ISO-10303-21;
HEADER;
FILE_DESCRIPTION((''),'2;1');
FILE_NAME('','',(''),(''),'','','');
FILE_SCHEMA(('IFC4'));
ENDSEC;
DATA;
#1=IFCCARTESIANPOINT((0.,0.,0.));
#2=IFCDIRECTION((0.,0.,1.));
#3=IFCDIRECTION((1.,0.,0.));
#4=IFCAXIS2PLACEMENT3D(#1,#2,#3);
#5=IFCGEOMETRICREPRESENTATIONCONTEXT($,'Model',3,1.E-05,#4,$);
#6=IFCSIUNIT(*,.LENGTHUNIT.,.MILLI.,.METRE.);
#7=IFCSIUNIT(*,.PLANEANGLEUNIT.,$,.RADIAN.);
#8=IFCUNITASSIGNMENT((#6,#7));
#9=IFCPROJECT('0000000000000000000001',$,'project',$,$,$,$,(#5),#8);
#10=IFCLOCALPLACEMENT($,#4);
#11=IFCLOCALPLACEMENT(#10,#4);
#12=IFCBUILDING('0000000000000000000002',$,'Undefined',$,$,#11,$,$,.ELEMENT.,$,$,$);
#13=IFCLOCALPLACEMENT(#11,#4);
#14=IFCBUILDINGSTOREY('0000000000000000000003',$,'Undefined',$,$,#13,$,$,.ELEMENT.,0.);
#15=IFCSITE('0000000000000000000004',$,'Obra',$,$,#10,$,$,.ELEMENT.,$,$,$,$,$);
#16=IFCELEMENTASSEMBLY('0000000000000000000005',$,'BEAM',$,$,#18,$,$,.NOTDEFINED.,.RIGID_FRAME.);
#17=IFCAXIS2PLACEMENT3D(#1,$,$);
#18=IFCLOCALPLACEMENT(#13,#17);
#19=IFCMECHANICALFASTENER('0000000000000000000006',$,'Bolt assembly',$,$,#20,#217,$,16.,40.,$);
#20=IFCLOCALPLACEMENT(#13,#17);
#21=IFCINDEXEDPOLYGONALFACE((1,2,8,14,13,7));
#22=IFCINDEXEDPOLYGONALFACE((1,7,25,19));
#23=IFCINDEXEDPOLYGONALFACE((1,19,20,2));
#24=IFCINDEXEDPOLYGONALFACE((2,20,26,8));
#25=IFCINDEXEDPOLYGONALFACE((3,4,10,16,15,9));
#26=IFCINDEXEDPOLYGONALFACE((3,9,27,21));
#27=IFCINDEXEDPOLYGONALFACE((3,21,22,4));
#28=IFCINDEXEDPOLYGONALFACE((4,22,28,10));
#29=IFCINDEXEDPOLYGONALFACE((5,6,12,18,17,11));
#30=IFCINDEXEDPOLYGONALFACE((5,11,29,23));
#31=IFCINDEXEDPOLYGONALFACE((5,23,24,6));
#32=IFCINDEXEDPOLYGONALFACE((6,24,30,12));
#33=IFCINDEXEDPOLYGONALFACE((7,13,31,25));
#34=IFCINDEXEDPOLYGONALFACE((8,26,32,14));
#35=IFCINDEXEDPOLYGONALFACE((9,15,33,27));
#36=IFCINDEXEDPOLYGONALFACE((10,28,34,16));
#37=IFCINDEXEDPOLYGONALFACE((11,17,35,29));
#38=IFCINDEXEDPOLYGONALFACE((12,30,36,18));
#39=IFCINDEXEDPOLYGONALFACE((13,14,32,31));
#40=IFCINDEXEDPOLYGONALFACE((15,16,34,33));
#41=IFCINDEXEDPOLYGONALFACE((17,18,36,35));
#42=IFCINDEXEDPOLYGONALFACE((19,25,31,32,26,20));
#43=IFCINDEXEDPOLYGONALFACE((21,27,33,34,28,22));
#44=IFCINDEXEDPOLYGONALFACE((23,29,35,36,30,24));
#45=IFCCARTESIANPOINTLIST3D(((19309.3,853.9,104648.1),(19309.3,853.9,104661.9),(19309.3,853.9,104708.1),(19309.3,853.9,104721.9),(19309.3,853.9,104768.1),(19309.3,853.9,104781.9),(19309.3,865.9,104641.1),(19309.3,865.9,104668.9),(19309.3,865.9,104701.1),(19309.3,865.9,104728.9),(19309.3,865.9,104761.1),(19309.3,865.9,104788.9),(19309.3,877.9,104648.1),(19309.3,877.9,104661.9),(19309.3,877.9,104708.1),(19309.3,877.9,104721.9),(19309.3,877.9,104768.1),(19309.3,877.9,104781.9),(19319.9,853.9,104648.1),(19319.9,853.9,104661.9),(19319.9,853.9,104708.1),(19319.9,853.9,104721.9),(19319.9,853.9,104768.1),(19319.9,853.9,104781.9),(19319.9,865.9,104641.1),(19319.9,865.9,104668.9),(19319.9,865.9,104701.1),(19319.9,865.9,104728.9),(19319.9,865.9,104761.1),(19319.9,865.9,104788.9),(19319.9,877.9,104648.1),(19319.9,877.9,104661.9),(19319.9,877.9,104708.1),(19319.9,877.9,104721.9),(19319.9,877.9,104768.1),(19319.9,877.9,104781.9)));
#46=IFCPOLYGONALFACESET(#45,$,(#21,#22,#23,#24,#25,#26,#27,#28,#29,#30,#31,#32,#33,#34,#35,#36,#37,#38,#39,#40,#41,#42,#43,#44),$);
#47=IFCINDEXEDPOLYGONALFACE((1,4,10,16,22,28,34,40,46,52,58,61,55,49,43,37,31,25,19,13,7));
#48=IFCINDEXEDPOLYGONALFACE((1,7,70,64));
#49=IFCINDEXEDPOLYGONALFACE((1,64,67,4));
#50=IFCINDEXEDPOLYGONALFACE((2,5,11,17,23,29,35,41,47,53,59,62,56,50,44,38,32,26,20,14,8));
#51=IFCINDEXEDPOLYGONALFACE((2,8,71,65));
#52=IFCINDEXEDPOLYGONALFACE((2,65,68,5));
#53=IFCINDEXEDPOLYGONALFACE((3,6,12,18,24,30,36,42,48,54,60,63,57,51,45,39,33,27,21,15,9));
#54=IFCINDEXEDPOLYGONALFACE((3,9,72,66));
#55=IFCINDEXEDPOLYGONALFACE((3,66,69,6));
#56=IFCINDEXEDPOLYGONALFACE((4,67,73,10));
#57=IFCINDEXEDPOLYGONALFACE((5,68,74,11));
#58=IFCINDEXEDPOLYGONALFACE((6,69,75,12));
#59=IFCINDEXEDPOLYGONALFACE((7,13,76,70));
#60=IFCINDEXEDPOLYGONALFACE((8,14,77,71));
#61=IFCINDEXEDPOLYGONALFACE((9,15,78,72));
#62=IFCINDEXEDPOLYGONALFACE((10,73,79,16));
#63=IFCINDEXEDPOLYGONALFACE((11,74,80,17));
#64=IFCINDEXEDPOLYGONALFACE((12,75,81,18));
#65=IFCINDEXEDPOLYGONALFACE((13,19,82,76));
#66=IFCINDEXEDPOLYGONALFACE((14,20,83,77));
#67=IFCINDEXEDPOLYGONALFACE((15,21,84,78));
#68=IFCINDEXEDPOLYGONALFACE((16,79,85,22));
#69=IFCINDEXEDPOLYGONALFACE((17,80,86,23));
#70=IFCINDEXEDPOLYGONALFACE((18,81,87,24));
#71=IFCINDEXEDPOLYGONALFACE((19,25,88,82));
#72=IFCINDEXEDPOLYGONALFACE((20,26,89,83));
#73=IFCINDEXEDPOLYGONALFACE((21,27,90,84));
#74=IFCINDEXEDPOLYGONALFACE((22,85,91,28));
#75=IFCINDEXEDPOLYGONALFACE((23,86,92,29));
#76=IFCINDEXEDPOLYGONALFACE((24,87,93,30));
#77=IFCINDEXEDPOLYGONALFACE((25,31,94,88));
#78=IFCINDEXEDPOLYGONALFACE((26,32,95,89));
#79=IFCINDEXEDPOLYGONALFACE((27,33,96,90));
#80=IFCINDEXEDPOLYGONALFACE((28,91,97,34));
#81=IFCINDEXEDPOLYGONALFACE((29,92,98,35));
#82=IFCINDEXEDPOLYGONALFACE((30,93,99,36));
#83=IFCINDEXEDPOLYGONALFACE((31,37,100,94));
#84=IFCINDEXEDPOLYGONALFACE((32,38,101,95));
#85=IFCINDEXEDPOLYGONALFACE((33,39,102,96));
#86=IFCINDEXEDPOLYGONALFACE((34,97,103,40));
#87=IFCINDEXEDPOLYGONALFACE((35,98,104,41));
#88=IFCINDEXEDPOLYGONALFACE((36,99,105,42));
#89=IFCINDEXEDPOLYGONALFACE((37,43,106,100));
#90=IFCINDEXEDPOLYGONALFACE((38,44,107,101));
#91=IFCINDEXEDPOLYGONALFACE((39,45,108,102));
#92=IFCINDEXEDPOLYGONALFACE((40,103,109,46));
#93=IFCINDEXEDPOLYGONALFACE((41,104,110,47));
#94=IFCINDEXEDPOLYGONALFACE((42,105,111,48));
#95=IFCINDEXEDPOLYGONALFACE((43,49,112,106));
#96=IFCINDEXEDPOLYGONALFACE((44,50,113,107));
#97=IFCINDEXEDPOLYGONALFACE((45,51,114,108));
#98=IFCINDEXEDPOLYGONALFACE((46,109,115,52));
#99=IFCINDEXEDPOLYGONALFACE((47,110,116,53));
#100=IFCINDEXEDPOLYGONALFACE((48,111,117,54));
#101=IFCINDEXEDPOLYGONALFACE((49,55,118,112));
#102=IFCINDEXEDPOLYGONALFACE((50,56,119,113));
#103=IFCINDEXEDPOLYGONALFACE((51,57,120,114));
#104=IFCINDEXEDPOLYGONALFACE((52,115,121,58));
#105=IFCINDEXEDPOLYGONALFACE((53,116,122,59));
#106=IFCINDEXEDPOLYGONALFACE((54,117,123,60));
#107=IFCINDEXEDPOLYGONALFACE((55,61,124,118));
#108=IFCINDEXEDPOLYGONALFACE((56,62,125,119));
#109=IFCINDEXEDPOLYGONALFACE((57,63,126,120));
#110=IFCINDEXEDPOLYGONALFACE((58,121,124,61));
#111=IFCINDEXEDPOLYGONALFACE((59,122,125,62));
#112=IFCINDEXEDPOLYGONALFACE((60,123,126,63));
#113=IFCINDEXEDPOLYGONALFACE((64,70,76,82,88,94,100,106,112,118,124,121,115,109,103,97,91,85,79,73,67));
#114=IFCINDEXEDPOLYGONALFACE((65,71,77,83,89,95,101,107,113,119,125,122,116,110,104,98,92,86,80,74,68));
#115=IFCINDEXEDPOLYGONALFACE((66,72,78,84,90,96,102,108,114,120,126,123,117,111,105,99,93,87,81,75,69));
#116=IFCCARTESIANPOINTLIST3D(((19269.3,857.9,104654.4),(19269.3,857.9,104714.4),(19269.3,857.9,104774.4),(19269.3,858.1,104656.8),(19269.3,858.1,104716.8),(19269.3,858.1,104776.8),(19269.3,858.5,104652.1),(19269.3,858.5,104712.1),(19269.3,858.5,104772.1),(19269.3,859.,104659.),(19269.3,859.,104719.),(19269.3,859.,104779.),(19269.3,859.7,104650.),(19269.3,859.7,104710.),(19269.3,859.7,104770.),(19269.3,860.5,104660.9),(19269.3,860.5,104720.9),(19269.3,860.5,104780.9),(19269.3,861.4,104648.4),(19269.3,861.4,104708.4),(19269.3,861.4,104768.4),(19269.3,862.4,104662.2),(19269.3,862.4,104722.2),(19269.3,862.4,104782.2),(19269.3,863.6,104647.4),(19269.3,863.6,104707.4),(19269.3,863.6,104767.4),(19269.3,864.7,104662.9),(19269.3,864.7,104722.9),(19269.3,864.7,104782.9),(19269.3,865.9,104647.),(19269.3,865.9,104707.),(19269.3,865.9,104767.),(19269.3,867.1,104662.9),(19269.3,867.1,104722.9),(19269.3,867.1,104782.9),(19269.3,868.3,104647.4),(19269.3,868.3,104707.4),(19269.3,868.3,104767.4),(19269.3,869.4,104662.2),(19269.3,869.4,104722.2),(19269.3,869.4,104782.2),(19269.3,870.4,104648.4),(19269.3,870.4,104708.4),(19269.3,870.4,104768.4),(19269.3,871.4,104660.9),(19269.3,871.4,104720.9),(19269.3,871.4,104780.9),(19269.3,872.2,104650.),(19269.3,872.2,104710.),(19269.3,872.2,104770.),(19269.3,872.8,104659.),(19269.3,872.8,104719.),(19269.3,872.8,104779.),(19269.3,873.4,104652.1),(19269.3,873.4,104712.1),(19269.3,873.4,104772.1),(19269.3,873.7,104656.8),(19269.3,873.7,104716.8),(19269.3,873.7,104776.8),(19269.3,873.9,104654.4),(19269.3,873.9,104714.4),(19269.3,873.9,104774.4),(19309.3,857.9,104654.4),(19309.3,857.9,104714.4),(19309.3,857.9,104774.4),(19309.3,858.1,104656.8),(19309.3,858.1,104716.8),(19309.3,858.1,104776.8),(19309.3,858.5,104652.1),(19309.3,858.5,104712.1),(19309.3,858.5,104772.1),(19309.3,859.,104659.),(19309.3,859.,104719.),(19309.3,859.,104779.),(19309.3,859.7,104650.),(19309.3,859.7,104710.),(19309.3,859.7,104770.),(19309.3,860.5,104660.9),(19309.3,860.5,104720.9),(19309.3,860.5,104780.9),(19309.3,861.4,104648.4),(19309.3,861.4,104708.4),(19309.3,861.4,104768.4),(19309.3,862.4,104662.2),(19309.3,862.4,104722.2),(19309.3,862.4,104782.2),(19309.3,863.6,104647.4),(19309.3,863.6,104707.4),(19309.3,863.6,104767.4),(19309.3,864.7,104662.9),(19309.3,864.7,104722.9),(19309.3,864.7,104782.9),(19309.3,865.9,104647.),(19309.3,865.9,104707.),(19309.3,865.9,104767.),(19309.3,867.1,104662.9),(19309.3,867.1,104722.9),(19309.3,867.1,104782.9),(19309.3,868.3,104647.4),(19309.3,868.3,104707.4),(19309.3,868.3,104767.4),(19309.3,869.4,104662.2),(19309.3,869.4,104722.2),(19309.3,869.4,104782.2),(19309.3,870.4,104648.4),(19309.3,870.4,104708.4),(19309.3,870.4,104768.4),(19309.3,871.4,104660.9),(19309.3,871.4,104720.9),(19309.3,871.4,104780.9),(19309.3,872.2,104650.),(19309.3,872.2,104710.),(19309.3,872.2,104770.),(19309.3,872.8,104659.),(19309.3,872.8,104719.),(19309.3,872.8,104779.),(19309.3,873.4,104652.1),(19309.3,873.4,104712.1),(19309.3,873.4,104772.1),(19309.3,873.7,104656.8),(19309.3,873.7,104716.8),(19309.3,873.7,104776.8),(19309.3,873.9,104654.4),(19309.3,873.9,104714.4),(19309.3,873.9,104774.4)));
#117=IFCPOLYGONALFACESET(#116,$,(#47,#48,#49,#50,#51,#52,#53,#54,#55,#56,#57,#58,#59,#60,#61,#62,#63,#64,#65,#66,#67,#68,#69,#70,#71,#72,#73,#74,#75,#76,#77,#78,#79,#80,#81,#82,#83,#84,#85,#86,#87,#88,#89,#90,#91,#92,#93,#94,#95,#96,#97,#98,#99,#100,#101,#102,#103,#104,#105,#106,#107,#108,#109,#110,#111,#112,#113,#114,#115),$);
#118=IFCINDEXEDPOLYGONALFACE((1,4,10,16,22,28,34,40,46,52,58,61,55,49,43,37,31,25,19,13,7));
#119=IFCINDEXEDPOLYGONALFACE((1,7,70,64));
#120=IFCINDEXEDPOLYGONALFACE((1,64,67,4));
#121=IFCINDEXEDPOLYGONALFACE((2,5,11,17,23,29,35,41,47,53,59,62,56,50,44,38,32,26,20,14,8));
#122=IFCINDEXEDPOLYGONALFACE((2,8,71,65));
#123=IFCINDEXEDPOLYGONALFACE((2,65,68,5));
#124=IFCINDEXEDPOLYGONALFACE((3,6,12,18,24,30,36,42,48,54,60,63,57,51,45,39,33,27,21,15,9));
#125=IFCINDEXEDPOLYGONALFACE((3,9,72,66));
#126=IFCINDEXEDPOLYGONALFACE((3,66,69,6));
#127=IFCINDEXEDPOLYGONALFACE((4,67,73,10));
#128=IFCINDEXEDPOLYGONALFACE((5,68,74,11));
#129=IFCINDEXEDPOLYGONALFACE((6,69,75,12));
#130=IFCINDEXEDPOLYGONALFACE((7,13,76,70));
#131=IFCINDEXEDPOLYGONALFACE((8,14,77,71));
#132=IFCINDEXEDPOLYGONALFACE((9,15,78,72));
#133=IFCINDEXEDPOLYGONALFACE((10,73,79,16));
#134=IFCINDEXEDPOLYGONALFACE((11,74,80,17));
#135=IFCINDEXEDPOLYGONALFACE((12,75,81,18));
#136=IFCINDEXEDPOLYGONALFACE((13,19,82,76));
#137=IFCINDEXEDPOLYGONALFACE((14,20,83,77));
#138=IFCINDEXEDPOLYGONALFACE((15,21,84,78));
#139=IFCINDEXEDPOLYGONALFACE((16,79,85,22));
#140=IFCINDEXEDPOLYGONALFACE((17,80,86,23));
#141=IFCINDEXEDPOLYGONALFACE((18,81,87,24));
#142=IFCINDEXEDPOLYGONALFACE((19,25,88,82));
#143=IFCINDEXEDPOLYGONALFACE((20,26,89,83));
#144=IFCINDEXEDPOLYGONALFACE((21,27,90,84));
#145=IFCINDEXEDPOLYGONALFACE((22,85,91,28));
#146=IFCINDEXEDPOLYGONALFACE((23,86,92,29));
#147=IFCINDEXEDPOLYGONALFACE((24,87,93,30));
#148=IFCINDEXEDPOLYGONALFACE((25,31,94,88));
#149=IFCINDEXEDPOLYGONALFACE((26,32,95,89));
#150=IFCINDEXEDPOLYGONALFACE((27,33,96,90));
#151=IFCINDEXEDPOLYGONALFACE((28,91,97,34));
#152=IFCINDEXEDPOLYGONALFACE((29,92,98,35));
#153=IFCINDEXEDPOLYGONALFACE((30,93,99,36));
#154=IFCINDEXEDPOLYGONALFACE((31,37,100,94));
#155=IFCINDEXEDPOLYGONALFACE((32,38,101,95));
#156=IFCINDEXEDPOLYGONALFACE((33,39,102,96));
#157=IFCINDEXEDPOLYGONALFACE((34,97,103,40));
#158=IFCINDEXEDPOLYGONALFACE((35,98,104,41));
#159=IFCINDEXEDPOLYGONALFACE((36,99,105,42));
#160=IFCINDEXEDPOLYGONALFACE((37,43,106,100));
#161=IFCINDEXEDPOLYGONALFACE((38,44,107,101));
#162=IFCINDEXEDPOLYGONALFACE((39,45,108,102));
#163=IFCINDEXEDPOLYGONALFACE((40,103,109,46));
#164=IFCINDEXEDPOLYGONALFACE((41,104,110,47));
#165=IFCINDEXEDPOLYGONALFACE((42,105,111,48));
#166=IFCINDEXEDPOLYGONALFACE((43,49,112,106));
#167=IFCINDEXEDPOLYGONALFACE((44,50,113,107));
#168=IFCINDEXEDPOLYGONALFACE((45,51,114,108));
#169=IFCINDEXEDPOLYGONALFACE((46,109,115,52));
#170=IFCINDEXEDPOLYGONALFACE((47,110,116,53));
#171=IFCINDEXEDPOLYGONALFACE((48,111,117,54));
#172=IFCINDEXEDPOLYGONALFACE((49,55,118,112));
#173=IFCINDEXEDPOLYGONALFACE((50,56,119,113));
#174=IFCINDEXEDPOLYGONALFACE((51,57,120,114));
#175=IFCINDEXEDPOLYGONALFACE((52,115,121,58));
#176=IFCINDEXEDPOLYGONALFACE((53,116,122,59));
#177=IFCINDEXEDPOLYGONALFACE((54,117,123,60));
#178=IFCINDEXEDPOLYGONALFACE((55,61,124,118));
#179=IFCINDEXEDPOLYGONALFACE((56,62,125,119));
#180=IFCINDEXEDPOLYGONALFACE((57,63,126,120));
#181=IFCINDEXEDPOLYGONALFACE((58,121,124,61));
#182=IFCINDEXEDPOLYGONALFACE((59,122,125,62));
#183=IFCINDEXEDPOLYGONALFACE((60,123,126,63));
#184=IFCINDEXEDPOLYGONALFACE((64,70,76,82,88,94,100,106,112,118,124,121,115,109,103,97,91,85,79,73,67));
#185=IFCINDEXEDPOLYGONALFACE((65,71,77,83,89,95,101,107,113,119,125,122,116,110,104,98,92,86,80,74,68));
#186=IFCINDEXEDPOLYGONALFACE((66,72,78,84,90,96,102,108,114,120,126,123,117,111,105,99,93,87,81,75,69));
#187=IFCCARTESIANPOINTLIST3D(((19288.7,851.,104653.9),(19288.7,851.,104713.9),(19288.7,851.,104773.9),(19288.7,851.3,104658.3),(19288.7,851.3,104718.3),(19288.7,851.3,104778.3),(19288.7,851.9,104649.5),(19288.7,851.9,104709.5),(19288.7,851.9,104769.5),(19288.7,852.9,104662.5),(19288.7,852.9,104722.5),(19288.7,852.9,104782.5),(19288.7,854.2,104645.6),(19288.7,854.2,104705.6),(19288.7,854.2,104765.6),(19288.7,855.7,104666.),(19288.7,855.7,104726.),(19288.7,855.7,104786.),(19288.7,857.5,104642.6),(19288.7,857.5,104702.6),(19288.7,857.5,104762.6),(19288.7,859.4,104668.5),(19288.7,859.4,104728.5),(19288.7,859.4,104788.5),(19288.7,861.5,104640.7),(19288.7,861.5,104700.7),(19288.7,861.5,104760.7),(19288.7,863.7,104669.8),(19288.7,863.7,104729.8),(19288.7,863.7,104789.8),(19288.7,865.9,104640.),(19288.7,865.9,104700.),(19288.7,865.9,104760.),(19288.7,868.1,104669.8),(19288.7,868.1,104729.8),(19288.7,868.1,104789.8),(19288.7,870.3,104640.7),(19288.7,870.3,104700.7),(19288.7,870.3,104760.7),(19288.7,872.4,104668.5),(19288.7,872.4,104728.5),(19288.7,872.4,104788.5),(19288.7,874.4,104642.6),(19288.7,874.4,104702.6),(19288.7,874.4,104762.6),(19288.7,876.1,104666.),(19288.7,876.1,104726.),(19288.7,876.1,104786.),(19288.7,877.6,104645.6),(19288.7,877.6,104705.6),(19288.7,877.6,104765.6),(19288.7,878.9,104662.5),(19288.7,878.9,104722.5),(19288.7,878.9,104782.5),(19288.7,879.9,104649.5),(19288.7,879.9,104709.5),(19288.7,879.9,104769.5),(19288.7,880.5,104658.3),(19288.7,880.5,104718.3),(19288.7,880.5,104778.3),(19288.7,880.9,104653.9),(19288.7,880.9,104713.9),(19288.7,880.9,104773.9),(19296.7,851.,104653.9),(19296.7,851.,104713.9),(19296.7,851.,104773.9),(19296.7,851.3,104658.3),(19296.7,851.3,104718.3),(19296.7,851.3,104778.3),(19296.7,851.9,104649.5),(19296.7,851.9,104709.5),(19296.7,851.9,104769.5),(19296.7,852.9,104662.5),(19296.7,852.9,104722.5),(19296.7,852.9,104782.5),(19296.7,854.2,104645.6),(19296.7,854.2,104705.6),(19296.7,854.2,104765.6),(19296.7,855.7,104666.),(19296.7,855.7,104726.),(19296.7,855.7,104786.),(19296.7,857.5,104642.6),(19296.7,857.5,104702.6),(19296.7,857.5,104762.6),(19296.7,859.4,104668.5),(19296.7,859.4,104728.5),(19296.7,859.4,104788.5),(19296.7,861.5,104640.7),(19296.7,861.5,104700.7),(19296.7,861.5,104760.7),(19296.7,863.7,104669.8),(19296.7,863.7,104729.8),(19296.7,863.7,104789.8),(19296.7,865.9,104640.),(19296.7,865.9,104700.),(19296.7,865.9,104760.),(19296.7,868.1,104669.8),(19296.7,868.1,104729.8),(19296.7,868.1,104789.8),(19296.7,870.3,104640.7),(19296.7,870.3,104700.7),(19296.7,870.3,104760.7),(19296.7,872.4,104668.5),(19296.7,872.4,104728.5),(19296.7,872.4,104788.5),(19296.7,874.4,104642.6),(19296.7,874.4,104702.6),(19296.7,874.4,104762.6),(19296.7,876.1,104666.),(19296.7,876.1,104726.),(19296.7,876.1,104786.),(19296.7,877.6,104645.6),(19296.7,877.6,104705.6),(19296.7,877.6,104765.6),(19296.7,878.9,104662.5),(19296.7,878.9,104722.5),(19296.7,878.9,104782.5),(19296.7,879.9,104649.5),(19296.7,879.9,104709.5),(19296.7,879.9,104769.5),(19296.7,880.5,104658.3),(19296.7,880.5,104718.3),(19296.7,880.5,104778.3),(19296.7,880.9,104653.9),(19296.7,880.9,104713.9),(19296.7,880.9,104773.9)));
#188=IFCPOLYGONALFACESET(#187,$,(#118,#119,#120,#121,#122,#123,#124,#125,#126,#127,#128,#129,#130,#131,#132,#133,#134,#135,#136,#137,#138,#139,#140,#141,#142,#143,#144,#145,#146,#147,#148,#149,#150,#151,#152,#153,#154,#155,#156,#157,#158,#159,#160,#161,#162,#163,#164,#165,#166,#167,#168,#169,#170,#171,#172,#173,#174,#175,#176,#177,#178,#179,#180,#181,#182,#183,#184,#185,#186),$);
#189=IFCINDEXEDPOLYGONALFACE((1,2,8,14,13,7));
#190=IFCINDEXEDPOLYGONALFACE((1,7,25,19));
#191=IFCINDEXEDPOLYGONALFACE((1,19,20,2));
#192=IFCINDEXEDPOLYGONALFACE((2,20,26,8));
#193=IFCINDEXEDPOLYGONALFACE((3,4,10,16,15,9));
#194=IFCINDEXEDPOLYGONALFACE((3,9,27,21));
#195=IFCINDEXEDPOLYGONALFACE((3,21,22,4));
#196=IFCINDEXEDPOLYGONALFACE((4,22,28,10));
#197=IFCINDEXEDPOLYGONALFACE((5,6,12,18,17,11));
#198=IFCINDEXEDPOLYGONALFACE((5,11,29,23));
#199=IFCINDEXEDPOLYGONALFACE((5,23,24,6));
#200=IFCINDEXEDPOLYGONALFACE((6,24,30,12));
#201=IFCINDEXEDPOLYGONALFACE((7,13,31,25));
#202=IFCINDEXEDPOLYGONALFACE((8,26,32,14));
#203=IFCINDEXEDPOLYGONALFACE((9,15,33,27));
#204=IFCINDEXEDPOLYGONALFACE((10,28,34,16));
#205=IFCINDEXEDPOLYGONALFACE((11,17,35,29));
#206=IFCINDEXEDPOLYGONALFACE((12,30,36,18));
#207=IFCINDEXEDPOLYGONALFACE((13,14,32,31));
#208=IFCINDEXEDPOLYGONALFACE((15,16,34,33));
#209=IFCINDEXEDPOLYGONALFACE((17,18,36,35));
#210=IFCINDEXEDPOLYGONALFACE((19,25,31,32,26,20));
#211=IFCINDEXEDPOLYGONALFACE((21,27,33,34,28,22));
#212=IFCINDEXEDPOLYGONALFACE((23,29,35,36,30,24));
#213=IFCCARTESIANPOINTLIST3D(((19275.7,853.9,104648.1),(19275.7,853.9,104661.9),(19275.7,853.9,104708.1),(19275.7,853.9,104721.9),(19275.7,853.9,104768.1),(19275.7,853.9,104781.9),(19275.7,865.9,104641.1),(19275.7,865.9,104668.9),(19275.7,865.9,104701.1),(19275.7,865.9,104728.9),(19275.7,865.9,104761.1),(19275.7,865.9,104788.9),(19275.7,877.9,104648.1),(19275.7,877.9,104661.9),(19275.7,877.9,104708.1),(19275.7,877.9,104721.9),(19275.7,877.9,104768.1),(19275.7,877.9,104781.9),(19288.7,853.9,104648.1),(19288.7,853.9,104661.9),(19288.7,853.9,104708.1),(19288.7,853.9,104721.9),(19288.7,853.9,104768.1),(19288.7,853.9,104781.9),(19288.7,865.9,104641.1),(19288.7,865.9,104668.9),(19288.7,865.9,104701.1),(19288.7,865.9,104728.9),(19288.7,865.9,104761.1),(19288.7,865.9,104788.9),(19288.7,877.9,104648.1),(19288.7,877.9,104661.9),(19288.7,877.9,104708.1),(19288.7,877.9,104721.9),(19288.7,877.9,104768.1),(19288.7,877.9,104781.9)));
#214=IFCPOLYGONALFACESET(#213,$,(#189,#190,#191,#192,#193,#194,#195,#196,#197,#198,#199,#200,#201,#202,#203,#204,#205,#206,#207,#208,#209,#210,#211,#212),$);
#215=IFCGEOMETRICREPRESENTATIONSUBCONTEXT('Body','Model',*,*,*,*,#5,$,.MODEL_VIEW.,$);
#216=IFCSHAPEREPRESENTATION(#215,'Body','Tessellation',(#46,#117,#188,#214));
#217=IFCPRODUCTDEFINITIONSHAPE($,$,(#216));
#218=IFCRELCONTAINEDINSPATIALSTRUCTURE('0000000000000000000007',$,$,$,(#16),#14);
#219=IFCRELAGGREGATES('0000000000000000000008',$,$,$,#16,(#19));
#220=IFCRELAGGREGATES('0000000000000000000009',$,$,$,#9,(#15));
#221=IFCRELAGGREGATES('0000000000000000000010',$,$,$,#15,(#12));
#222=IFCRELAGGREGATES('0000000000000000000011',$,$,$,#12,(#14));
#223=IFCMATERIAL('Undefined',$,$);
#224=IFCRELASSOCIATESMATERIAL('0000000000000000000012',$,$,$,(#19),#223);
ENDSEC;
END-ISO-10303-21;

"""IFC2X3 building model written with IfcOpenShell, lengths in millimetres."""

from ifc_helpers import new_model, si_unit, frame, origin_with_axes, origin_2d_with_axis, place, context, subcontext, project, spatial, polyline, circle, outline, extrude, source, transform, mapped, material, element, aggregate, save


model = new_model("IFC2X3")

# Units and contexts
model_context = context("Model", 3, precision=1e-05, world=origin_with_axes())
body_context = subcontext(model_context, "Body", "Model", "MODEL_VIEW")
ifc_project = project(units=[si_unit("LENGTHUNIT", "METRE", prefix="MILLI"), si_unit("PLANEANGLEUNIT", "RADIAN")], contexts=[model_context])

# Site, building, storey
site_placement = place(None, origin_with_axes())
site = spatial("IfcSite", under=ifc_project, at=site_placement, Name="Obra", CompositionType="ELEMENT")
building_placement = place(site_placement, origin_with_axes())
building = spatial("IfcBuilding", under=site, at=building_placement, Name="Undefined", CompositionType="ELEMENT")
storey_placement = place(building_placement, origin_with_axes())
storey = spatial("IfcBuildingStorey", under=building, at=storey_placement, Name="Undefined", CompositionType="ELEMENT", Elevation=0.0)

# Element assembly, mechanical fastener
assembly_1_placement = place(storey_placement, origin_with_axes())
assembly_1 = element("IfcElementAssembly", 1, at=assembly_1_placement, inside=storey, Name="BEAM", AssemblyPlace="NOTDEFINED", PredefinedType="RIGID_FRAME")
ifc_material_1 = material(Name="Undefined")
shared_shape_1 = source(origin_with_axes(), body_context, "Body", "SweptSolid", [
    extrude(outline(polyline([(13.9, 0.0), (6.9, 12.0), (-6.9, 12.0), (-13.9, 0.0), (-6.9, -12.0), (6.9, -12.0), (13.9, 0.0)])), frame((0.0, -19.9, 0.0), z_axis=(0.0, 1.0, 0.0), x_axis=(1.0, 0.0, 0.0)), (0.0, 0.0, 1.0), 10.6),
    extrude(circle(Radius=8.0, at=origin_2d_with_axis()), frame((0.0, -9.3, 0.0), z_axis=(0.0, 1.0, 0.0), x_axis=(1.0, 0.0, 0.0)), (0.0, 0.0, 1.0), 40.0),
    extrude(circle(Radius=15.0, at=origin_2d_with_axis()), frame((0.0, 3.3, 0.0), z_axis=(0.0, 1.0, 0.0), x_axis=(1.0, 0.0, 0.0)), (0.0, 0.0, 1.0), 8.0),
    extrude(outline(polyline([(13.9, 0.0), (6.9, 12.0), (-6.9, 12.0), (-13.9, 0.0), (-6.9, -12.0), (6.9, -12.0), (13.9, 0.0)])), frame((0.0, 11.3, 0.0), z_axis=(0.0, 1.0, 0.0), x_axis=(1.0, 0.0, 0.0)), (0.0, 0.0, 1.0), 13.0),
])
mechanical_fastener_1_placement = place(assembly_1_placement, frame((19300.0, 830.9, 104850.0), z_axis=(0.0, 1.0, 0.0), x_axis=(0.0, 0.0, -1.0)))
mechanical_fastener_1 = element("IfcMechanicalFastener", 2, at=mechanical_fastener_1_placement, material=ifc_material_1, Name="Bolt assembly", NominalDiameter=16.0, NominalLength=40.0, context=body_context, shape_type="MappedRepresentation", body=[
    mapped(shared_shape_1, transform((75.0, 0.0, 35.0))),
    mapped(shared_shape_1, transform((135.0, 0.0, 35.0))),
    mapped(shared_shape_1, transform((195.0, 0.0, 35.0))),
])
aggregate(assembly_1, [mechanical_fastener_1])

save(model, "model.ifc")
